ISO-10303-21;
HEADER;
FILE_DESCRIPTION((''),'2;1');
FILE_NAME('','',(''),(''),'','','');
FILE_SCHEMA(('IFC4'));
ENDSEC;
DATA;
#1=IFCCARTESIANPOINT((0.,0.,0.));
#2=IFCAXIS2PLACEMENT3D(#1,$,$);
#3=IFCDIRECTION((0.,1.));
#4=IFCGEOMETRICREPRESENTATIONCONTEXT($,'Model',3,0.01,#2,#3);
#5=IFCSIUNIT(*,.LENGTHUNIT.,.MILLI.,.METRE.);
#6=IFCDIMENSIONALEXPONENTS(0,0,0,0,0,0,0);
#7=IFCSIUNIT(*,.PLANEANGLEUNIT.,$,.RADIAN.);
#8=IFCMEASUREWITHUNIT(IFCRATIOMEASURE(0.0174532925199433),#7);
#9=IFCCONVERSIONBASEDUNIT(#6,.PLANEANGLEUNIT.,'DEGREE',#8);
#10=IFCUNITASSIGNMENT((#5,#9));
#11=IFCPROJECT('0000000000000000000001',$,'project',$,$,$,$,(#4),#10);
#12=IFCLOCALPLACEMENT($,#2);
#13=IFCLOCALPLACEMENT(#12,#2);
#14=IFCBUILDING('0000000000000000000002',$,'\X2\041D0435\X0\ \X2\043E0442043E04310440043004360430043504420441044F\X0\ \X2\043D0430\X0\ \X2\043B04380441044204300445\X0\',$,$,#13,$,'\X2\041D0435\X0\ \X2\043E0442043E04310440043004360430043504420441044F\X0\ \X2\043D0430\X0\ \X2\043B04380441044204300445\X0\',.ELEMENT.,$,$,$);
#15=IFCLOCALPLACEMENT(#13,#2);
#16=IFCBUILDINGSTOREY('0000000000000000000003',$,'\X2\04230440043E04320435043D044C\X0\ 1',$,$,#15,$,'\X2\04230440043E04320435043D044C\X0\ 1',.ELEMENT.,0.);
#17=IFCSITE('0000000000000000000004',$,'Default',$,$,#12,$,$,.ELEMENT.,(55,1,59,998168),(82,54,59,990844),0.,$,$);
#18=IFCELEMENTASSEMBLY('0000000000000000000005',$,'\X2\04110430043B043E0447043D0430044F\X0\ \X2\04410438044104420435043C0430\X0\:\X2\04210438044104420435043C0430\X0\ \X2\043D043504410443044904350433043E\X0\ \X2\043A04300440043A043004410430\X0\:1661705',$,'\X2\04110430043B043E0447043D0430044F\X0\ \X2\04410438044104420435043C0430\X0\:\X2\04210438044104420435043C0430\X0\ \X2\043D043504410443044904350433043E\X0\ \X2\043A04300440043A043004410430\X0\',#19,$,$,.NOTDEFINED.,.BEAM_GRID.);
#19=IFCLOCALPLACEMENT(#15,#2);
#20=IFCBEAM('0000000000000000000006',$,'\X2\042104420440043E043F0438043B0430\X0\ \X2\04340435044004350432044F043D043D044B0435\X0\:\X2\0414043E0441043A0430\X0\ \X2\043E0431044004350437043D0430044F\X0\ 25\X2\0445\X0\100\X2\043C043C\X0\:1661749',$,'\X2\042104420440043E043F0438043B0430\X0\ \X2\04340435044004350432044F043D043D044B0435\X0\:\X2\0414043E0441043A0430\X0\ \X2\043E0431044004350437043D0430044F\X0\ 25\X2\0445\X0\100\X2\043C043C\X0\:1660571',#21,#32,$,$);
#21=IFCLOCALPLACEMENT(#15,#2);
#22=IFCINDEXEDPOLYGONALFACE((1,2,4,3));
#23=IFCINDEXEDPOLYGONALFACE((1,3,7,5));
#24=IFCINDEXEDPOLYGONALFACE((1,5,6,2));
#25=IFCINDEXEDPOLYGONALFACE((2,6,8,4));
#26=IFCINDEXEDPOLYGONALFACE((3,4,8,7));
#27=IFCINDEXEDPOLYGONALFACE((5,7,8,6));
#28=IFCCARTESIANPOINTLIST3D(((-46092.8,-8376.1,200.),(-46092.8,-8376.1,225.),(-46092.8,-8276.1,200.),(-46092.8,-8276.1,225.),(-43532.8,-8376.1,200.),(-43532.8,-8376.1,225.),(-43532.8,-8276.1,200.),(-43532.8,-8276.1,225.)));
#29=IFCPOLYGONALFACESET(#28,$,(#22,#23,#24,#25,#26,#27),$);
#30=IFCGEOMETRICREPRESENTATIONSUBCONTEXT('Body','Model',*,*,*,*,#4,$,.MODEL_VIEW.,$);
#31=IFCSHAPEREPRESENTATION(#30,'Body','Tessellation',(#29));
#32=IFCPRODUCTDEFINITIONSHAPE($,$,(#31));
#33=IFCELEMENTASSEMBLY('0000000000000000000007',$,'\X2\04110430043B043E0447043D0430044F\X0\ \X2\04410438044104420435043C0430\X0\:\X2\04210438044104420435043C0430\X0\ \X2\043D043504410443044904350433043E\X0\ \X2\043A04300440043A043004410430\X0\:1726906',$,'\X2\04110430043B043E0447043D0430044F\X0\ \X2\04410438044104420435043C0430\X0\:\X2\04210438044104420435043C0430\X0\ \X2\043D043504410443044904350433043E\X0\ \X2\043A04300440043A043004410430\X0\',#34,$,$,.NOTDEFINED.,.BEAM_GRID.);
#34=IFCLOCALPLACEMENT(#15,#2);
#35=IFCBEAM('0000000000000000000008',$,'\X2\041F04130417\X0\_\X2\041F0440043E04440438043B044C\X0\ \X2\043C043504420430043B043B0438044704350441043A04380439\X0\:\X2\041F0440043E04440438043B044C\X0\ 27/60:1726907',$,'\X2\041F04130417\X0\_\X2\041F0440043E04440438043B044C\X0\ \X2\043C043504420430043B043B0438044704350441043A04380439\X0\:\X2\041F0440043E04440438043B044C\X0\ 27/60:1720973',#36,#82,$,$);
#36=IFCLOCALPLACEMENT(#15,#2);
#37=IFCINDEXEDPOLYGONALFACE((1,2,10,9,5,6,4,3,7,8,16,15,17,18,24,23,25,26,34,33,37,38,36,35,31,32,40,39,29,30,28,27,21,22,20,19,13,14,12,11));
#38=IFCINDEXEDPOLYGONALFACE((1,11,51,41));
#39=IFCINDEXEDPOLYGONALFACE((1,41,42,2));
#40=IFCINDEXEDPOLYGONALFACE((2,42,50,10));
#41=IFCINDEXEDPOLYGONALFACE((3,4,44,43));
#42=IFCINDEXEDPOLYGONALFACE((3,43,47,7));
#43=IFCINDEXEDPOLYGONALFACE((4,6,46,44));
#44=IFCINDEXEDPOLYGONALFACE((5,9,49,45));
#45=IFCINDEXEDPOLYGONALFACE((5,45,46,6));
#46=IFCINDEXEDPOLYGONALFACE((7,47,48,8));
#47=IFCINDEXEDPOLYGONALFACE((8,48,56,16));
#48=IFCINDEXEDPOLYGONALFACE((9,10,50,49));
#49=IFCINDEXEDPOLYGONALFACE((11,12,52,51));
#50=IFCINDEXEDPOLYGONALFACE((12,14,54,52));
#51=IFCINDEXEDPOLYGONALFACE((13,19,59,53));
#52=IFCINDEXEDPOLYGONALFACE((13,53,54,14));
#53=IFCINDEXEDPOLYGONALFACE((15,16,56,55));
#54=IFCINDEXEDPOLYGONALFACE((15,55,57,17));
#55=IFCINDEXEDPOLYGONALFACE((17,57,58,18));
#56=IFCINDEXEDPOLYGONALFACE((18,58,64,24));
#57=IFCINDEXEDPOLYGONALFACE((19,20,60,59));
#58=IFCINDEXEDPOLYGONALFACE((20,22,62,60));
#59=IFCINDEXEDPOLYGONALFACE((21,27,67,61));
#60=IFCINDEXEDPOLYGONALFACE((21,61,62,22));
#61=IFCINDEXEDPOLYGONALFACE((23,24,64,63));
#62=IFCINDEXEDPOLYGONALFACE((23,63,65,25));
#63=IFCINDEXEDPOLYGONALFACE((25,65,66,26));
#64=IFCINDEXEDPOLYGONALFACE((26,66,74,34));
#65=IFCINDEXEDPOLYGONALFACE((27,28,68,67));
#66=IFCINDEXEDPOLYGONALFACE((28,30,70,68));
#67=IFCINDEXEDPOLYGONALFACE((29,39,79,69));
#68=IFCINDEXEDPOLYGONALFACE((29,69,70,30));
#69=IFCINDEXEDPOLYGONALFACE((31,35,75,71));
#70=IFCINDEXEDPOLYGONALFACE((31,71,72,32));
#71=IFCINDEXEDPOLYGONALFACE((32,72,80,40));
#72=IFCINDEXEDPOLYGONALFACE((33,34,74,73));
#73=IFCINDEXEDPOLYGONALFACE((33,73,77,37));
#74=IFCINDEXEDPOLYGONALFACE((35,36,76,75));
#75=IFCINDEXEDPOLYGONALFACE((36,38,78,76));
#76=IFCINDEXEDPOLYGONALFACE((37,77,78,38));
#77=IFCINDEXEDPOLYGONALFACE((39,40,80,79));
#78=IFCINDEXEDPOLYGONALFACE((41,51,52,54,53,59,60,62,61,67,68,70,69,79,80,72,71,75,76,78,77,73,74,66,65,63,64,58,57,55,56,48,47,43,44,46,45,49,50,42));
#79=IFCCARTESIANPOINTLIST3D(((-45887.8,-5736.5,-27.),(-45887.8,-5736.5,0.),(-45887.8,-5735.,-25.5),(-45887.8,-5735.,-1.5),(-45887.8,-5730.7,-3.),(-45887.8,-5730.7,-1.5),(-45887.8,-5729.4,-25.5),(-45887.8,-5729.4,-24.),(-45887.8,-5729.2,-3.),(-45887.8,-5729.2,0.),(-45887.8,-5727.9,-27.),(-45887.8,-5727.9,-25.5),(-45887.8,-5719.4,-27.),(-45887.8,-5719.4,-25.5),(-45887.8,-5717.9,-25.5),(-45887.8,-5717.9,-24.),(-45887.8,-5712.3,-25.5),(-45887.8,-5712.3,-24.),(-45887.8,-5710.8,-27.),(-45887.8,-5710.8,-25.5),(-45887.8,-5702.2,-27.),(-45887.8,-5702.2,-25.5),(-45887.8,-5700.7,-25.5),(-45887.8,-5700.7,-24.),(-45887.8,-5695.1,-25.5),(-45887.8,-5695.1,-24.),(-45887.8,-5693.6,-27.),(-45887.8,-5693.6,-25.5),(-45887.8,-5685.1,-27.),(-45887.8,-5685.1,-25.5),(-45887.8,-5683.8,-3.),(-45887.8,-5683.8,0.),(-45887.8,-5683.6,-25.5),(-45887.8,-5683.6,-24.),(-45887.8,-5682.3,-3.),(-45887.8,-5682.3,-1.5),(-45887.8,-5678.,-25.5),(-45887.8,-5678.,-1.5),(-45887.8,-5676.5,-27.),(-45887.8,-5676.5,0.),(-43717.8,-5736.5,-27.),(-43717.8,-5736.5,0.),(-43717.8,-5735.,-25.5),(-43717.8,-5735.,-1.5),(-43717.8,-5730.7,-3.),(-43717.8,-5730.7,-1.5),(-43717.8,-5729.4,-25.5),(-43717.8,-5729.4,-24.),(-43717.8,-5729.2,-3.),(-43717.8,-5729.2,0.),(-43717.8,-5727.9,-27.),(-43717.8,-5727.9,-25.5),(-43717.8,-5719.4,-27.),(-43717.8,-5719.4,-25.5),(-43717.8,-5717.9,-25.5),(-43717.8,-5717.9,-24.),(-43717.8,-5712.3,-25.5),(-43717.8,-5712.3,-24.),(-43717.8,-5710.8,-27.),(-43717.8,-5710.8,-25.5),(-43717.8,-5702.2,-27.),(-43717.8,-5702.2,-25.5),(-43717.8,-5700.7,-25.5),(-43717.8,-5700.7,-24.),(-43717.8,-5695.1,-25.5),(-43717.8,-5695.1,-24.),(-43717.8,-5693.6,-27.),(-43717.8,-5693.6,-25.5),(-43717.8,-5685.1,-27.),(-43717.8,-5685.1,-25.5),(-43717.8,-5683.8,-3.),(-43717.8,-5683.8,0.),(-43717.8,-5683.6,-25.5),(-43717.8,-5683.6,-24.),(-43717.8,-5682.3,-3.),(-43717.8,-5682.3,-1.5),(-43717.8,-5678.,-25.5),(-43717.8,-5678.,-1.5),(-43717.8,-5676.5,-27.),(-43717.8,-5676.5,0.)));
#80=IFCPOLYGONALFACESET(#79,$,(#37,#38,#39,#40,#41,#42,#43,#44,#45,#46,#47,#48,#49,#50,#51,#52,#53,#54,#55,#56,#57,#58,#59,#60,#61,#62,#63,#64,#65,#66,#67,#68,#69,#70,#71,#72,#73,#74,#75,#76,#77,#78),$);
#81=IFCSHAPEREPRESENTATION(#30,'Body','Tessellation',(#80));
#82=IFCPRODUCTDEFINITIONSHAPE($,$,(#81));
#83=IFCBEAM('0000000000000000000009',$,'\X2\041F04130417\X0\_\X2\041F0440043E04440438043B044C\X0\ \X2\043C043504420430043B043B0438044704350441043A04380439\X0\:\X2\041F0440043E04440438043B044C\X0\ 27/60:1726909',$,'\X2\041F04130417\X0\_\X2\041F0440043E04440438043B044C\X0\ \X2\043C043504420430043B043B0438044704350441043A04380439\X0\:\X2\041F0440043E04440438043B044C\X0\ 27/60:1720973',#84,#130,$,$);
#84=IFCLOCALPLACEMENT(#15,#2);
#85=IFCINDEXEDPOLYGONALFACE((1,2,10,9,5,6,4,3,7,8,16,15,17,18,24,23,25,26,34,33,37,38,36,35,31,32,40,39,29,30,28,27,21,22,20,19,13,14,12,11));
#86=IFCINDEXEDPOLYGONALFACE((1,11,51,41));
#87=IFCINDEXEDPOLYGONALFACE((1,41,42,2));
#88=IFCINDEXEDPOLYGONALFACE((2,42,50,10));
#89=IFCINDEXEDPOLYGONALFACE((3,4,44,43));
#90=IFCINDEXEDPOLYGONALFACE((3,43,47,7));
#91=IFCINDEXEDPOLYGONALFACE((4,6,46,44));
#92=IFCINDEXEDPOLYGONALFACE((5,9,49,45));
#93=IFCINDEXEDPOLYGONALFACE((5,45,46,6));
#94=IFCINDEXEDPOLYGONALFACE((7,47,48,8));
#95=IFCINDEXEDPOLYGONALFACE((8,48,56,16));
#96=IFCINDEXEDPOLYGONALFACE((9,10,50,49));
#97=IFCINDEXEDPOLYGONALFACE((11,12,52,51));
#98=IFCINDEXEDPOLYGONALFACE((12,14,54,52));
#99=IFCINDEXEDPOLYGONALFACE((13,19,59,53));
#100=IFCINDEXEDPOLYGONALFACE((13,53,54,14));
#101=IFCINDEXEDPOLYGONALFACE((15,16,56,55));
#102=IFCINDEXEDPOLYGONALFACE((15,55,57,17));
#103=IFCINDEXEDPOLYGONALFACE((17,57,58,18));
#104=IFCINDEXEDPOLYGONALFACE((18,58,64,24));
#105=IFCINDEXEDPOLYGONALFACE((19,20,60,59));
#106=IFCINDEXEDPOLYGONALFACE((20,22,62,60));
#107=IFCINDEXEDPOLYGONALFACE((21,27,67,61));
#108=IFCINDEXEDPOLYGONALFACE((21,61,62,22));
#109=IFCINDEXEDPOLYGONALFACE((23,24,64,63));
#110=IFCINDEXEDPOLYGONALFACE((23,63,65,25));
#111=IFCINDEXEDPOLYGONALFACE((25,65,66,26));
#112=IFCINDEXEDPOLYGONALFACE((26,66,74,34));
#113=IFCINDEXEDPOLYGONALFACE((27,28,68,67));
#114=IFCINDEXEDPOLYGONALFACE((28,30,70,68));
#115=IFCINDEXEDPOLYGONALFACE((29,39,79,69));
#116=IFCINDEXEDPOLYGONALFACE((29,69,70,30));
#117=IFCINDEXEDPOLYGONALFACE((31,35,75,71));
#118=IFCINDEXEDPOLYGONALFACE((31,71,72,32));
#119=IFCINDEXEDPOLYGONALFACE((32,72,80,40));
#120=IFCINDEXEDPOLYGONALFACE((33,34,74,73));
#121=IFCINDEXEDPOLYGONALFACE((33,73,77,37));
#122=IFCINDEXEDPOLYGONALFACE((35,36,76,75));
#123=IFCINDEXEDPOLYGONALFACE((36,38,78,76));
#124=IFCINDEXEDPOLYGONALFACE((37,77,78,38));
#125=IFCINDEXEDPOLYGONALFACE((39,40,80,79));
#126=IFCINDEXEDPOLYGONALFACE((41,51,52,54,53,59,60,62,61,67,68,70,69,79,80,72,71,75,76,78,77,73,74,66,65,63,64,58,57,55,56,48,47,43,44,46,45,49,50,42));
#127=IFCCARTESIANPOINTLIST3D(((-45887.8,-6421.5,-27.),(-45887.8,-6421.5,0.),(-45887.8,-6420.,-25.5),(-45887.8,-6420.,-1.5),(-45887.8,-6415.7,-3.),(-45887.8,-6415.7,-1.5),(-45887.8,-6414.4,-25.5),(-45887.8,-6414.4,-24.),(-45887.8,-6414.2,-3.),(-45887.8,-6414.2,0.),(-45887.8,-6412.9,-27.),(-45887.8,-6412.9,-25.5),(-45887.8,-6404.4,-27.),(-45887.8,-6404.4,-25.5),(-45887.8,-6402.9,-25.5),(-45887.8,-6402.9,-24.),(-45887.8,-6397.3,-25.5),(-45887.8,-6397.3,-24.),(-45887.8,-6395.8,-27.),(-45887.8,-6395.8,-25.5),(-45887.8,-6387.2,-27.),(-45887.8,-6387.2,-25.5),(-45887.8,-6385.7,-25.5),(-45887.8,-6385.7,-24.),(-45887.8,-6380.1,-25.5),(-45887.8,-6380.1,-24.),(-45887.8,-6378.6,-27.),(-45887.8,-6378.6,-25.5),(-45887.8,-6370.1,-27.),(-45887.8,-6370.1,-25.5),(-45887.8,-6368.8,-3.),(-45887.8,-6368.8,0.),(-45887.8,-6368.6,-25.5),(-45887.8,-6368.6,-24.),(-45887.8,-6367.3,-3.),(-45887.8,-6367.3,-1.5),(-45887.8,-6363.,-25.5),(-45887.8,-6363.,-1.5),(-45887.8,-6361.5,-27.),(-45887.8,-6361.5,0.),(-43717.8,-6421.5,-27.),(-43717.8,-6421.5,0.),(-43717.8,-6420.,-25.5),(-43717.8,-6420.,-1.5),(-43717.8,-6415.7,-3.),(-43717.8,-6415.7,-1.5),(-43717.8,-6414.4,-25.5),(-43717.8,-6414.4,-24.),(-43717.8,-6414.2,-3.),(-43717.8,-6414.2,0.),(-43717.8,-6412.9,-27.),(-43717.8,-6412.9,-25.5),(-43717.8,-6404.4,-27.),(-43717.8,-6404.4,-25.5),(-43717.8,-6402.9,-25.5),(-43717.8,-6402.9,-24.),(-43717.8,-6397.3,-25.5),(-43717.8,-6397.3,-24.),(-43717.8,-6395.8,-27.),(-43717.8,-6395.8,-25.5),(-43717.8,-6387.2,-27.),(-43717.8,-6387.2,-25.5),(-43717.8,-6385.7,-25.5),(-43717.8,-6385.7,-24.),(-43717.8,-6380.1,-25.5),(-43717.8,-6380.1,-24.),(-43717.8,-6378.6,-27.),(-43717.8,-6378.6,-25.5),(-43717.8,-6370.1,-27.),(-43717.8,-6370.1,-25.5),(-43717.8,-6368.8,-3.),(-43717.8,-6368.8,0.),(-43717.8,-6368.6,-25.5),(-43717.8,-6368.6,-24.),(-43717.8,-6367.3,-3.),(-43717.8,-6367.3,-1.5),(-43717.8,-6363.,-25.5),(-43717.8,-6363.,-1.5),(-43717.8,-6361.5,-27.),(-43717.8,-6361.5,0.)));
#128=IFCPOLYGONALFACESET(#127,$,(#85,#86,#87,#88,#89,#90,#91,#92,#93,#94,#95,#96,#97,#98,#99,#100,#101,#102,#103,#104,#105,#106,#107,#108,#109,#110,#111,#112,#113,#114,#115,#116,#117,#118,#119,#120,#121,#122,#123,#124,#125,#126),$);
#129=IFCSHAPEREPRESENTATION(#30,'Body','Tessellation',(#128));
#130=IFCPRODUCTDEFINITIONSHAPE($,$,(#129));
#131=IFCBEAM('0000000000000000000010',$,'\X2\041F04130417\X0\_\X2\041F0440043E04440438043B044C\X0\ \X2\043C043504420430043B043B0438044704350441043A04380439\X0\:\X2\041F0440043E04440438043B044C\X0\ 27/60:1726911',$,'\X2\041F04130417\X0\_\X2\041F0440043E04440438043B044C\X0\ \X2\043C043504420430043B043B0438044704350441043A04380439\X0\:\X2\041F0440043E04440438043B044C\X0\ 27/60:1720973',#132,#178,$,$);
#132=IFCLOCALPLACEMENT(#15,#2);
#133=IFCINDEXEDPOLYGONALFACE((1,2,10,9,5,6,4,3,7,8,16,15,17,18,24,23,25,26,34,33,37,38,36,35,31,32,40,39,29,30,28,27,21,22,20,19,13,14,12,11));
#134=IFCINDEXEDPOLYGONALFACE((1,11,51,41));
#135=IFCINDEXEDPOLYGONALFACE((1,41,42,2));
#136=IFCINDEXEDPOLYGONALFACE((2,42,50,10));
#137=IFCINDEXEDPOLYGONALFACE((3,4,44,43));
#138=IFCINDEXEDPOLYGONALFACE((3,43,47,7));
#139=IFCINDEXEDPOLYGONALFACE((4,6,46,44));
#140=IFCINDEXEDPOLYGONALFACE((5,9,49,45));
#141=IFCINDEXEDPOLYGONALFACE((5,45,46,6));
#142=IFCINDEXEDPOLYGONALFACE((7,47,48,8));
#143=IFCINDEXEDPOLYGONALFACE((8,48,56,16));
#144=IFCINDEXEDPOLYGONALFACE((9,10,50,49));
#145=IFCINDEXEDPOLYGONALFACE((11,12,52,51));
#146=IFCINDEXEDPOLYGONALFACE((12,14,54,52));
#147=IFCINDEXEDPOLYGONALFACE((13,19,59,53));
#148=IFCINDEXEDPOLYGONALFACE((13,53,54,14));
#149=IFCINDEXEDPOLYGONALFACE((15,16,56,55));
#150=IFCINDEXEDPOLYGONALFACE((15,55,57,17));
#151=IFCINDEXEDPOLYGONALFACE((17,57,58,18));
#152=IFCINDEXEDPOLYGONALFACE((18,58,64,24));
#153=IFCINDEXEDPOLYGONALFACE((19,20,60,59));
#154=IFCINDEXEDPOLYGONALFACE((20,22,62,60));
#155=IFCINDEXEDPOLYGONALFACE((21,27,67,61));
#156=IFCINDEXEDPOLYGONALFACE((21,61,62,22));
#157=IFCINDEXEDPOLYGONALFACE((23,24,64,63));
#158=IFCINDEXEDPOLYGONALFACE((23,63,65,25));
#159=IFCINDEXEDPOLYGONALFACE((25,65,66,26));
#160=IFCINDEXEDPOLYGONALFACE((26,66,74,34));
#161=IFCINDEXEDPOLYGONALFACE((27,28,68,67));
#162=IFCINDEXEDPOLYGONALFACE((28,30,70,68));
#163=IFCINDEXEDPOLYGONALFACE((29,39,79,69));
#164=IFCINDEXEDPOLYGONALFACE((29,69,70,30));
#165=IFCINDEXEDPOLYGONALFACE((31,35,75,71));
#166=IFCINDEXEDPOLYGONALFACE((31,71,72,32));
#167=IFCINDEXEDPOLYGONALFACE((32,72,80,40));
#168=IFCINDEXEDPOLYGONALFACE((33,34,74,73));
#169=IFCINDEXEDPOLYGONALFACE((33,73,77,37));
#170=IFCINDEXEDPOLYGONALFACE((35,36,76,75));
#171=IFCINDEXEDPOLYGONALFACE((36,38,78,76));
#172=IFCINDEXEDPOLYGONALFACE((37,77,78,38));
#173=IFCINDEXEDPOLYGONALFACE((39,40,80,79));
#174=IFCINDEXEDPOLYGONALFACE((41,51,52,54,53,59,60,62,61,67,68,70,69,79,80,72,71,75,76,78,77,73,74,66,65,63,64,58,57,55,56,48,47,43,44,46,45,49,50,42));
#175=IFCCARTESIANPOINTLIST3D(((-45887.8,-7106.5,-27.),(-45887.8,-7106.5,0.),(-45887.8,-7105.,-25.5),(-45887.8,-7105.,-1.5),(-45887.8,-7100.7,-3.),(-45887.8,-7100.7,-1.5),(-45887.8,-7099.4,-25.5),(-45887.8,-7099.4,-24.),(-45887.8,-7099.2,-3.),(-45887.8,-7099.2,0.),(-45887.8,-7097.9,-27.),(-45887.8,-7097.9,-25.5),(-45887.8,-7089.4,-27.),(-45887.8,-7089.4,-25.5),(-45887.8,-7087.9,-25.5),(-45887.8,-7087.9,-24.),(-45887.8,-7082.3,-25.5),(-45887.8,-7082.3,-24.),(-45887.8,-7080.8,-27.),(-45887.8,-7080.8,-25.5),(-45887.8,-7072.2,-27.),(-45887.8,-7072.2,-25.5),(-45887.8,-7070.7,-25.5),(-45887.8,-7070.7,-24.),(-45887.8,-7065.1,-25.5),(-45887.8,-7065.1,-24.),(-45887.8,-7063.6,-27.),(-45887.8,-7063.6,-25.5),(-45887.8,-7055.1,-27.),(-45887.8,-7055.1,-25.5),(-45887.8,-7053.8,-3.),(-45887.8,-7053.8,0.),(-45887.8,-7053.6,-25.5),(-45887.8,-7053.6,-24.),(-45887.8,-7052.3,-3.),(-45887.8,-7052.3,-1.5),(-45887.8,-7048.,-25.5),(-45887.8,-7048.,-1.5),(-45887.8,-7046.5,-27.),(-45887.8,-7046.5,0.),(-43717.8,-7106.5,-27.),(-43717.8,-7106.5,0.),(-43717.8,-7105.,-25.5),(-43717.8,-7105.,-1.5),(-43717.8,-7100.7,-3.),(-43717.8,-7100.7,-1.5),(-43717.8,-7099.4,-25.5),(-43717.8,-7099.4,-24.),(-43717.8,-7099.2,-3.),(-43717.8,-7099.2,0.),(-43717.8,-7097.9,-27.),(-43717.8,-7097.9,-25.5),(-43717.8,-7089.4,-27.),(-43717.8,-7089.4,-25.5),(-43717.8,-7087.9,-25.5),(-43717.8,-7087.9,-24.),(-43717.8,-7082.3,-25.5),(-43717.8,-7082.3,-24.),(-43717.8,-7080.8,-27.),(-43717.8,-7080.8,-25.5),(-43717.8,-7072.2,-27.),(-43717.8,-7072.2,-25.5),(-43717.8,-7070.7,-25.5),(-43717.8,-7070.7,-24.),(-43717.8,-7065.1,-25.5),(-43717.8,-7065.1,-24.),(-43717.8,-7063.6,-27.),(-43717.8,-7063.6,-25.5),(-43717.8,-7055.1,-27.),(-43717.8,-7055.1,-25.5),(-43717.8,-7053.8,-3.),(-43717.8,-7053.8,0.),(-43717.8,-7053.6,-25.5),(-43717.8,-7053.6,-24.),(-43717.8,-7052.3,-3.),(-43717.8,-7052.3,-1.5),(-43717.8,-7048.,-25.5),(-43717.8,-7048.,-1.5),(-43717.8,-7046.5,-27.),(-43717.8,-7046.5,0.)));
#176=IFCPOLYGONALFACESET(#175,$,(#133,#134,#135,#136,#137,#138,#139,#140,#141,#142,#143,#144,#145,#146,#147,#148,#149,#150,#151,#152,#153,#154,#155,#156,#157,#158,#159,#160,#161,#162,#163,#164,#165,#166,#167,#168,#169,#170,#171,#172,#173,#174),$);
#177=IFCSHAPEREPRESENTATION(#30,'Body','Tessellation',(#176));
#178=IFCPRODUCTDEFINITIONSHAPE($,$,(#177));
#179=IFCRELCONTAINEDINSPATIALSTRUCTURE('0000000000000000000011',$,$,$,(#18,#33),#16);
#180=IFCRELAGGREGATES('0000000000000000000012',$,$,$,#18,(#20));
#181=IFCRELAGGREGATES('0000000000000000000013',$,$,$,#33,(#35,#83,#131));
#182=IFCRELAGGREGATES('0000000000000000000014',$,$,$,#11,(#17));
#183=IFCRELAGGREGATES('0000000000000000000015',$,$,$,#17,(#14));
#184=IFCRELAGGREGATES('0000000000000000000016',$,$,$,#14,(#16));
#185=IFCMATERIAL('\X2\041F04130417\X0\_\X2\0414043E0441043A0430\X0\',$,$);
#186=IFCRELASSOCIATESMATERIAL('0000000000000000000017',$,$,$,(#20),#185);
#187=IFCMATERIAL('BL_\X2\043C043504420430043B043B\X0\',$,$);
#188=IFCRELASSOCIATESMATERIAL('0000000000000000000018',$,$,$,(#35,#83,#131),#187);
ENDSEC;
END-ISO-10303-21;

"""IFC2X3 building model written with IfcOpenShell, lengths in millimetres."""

from ifc_helpers import new_model, entity, si_unit, converted_unit, direction, frame, frame_2d, origin, place, context, subcontext, project, spatial, polyline, rectangle, outline, extrude, material, element, aggregate, save


model = new_model("IFC2X3")

# Units and contexts
model_context = context("Model", 3, precision=0.01, world=origin(), true_north=direction((0.0, 1.0)))
body_context = subcontext(model_context, "Body", "Model", "MODEL_VIEW")
ifc_project = project(units=[si_unit("LENGTHUNIT", "METRE", prefix="MILLI"), converted_unit("PLANEANGLEUNIT", "DEGREE", entity("IfcRatioMeasure", 0.0174532925199433), si_unit("PLANEANGLEUNIT", "RADIAN"), dimensions=[0, 0, 0, 0, 0, 0, 0])], contexts=[model_context])

# Site, building, storey
site_placement = place(None, origin())
site = spatial("IfcSite", under=ifc_project, at=site_placement, Name="Default", CompositionType="ELEMENT", RefLatitude=(55, 1, 59, 998168), RefLongitude=(82, 54, 59, 990844), RefElevation=0.0)
building_placement = place(site_placement, origin())
building = spatial("IfcBuilding", under=site, at=building_placement, Name="Не отображается на листах", LongName="Не отображается на листах", CompositionType="ELEMENT")
storey_placement = place(building_placement, frame((0.0, 0.0, 0.0)))
storey = spatial("IfcBuildingStorey", under=building, at=storey_placement, Name="Уровень 1", LongName="Уровень 1", CompositionType="ELEMENT", Elevation=0.0)

# Element assemblies, beams
ifc_material_1 = material(Name="ПГЗ_Доска")
assembly_1_placement = place(storey_placement, origin())
assembly_1 = element("IfcElementAssembly", 1, at=assembly_1_placement, inside=storey, Name="Балочная система:Система несущего каркаса:1661705", ObjectType="Балочная система:Система несущего каркаса", AssemblyPlace="NOTDEFINED", PredefinedType="BEAM_GRID")
beam_1_placement = place(assembly_1_placement, frame((-46092.8, -8326.1, 0.0)))
beam_1 = element("IfcBeam", 2, at=beam_1_placement, material=ifc_material_1, Name="Стропила деревянные:Доска обрезная 25х100мм:1661749", ObjectType="Стропила деревянные:Доска обрезная 25х100мм:1660571", context=body_context, shape_type="SweptSolid", body=[
    extrude(rectangle(XDim=25.0, YDim=100.0, at=frame_2d((0.0, 0.0), x_axis=(1.0, 0.0))), frame((0.0, 0.0, 212.5), z_axis=(1.0, 0.0, 0.0), x_axis=(0.0, 0.0, -1.0)), (0.0, 0.0, 1.0), 2560.0),
])
aggregate(assembly_1, [beam_1])
assembly_2_placement = place(storey_placement, origin())
assembly_2 = element("IfcElementAssembly", 3, at=assembly_2_placement, inside=storey, Name="Балочная система:Система несущего каркаса:1726906", ObjectType="Балочная система:Система несущего каркаса", AssemblyPlace="NOTDEFINED", PredefinedType="BEAM_GRID")
ifc_material_2 = material(Name="BL_металл")
beam_2_placement = place(assembly_2_placement, frame((-45887.8, -5706.5, 0.0)))
beam_2 = element("IfcBeam", 4, at=beam_2_placement, material=ifc_material_2, Name="ПГЗ_Профиль металлический:Профиль 27/60:1726907", ObjectType="ПГЗ_Профиль металлический:Профиль 27/60:1720973", context=body_context, shape_type="SweptSolid", body=[
    extrude(outline(polyline([(-18.4, -30.0), (8.6, -30.0), (8.6, -21.4), (7.1, -21.4), (7.1, -12.9), (8.6, -12.9), (8.6, -4.3), (7.1, -4.3), (7.1, 4.3), (8.6, 4.3), (8.6, 12.9), (7.1, 12.9), (7.1, 21.4), (8.6, 21.4), (8.6, 30.0), (-18.4, 30.0), (-18.4, 22.7), (-15.4, 22.7), (-15.4, 24.2), (-16.9, 24.2), (-16.9, 28.5), (7.1, 28.5), (7.1, 22.9), (5.6, 22.9), (5.6, 11.4), (7.1, 11.4), (7.1, 5.8), (5.6, 5.8), (5.6, -5.8), (7.1, -5.8), (7.1, -11.4), (5.6, -11.4), (5.6, -22.9), (7.1, -22.9), (7.1, -28.5), (-16.9, -28.5), (-16.9, -24.2), (-15.4, -24.2), (-15.4, -22.7), (-18.4, -22.7), (-18.4, -30.0)])), frame((0.0, 0.0, -18.4), z_axis=(1.0, 0.0, 0.0), x_axis=(0.0, 0.0, -1.0)), (0.0, 0.0, 1.0), 2170.0),
])
beam_3_placement = place(assembly_2_placement, frame((-45887.8, -6391.5, 0.0)))
beam_3 = element("IfcBeam", 5, at=beam_3_placement, material=ifc_material_2, Name="ПГЗ_Профиль металлический:Профиль 27/60:1726909", ObjectType="ПГЗ_Профиль металлический:Профиль 27/60:1720973", context=body_context, shape_type="SweptSolid", body=[
    extrude(outline(polyline([(-18.4, -30.0), (8.6, -30.0), (8.6, -21.4), (7.1, -21.4), (7.1, -12.9), (8.6, -12.9), (8.6, -4.3), (7.1, -4.3), (7.1, 4.3), (8.6, 4.3), (8.6, 12.9), (7.1, 12.9), (7.1, 21.4), (8.6, 21.4), (8.6, 30.0), (-18.4, 30.0), (-18.4, 22.7), (-15.4, 22.7), (-15.4, 24.2), (-16.9, 24.2), (-16.9, 28.5), (7.1, 28.5), (7.1, 22.9), (5.6, 22.9), (5.6, 11.4), (7.1, 11.4), (7.1, 5.8), (5.6, 5.8), (5.6, -5.8), (7.1, -5.8), (7.1, -11.4), (5.6, -11.4), (5.6, -22.9), (7.1, -22.9), (7.1, -28.5), (-16.9, -28.5), (-16.9, -24.2), (-15.4, -24.2), (-15.4, -22.7), (-18.4, -22.7), (-18.4, -30.0)])), frame((0.0, 0.0, -18.4), z_axis=(1.0, 0.0, 0.0), x_axis=(0.0, 0.0, -1.0)), (0.0, 0.0, 1.0), 2170.0),
])
beam_4_placement = place(assembly_2_placement, frame((-45887.8, -7076.5, 0.0)))
beam_4 = element("IfcBeam", 6, at=beam_4_placement, material=ifc_material_2, Name="ПГЗ_Профиль металлический:Профиль 27/60:1726911", ObjectType="ПГЗ_Профиль металлический:Профиль 27/60:1720973", context=body_context, shape_type="SweptSolid", body=[
    extrude(outline(polyline([(-18.4, -30.0), (8.6, -30.0), (8.6, -21.4), (7.1, -21.4), (7.1, -12.9), (8.6, -12.9), (8.6, -4.3), (7.1, -4.3), (7.1, 4.3), (8.6, 4.3), (8.6, 12.9), (7.1, 12.9), (7.1, 21.4), (8.6, 21.4), (8.6, 30.0), (-18.4, 30.0), (-18.4, 22.7), (-15.4, 22.7), (-15.4, 24.2), (-16.9, 24.2), (-16.9, 28.5), (7.1, 28.5), (7.1, 22.9), (5.6, 22.9), (5.6, 11.4), (7.1, 11.4), (7.1, 5.8), (5.6, 5.8), (5.6, -5.8), (7.1, -5.8), (7.1, -11.4), (5.6, -11.4), (5.6, -22.9), (7.1, -22.9), (7.1, -28.5), (-16.9, -28.5), (-16.9, -24.2), (-15.4, -24.2), (-15.4, -22.7), (-18.4, -22.7), (-18.4, -30.0)])), frame((0.0, 0.0, -18.4), z_axis=(1.0, 0.0, 0.0), x_axis=(0.0, 0.0, -1.0)), (0.0, 0.0, 1.0), 2170.0),
])
aggregate(assembly_2, [beam_2, beam_3, beam_4])

save(model, "model.ifc")
